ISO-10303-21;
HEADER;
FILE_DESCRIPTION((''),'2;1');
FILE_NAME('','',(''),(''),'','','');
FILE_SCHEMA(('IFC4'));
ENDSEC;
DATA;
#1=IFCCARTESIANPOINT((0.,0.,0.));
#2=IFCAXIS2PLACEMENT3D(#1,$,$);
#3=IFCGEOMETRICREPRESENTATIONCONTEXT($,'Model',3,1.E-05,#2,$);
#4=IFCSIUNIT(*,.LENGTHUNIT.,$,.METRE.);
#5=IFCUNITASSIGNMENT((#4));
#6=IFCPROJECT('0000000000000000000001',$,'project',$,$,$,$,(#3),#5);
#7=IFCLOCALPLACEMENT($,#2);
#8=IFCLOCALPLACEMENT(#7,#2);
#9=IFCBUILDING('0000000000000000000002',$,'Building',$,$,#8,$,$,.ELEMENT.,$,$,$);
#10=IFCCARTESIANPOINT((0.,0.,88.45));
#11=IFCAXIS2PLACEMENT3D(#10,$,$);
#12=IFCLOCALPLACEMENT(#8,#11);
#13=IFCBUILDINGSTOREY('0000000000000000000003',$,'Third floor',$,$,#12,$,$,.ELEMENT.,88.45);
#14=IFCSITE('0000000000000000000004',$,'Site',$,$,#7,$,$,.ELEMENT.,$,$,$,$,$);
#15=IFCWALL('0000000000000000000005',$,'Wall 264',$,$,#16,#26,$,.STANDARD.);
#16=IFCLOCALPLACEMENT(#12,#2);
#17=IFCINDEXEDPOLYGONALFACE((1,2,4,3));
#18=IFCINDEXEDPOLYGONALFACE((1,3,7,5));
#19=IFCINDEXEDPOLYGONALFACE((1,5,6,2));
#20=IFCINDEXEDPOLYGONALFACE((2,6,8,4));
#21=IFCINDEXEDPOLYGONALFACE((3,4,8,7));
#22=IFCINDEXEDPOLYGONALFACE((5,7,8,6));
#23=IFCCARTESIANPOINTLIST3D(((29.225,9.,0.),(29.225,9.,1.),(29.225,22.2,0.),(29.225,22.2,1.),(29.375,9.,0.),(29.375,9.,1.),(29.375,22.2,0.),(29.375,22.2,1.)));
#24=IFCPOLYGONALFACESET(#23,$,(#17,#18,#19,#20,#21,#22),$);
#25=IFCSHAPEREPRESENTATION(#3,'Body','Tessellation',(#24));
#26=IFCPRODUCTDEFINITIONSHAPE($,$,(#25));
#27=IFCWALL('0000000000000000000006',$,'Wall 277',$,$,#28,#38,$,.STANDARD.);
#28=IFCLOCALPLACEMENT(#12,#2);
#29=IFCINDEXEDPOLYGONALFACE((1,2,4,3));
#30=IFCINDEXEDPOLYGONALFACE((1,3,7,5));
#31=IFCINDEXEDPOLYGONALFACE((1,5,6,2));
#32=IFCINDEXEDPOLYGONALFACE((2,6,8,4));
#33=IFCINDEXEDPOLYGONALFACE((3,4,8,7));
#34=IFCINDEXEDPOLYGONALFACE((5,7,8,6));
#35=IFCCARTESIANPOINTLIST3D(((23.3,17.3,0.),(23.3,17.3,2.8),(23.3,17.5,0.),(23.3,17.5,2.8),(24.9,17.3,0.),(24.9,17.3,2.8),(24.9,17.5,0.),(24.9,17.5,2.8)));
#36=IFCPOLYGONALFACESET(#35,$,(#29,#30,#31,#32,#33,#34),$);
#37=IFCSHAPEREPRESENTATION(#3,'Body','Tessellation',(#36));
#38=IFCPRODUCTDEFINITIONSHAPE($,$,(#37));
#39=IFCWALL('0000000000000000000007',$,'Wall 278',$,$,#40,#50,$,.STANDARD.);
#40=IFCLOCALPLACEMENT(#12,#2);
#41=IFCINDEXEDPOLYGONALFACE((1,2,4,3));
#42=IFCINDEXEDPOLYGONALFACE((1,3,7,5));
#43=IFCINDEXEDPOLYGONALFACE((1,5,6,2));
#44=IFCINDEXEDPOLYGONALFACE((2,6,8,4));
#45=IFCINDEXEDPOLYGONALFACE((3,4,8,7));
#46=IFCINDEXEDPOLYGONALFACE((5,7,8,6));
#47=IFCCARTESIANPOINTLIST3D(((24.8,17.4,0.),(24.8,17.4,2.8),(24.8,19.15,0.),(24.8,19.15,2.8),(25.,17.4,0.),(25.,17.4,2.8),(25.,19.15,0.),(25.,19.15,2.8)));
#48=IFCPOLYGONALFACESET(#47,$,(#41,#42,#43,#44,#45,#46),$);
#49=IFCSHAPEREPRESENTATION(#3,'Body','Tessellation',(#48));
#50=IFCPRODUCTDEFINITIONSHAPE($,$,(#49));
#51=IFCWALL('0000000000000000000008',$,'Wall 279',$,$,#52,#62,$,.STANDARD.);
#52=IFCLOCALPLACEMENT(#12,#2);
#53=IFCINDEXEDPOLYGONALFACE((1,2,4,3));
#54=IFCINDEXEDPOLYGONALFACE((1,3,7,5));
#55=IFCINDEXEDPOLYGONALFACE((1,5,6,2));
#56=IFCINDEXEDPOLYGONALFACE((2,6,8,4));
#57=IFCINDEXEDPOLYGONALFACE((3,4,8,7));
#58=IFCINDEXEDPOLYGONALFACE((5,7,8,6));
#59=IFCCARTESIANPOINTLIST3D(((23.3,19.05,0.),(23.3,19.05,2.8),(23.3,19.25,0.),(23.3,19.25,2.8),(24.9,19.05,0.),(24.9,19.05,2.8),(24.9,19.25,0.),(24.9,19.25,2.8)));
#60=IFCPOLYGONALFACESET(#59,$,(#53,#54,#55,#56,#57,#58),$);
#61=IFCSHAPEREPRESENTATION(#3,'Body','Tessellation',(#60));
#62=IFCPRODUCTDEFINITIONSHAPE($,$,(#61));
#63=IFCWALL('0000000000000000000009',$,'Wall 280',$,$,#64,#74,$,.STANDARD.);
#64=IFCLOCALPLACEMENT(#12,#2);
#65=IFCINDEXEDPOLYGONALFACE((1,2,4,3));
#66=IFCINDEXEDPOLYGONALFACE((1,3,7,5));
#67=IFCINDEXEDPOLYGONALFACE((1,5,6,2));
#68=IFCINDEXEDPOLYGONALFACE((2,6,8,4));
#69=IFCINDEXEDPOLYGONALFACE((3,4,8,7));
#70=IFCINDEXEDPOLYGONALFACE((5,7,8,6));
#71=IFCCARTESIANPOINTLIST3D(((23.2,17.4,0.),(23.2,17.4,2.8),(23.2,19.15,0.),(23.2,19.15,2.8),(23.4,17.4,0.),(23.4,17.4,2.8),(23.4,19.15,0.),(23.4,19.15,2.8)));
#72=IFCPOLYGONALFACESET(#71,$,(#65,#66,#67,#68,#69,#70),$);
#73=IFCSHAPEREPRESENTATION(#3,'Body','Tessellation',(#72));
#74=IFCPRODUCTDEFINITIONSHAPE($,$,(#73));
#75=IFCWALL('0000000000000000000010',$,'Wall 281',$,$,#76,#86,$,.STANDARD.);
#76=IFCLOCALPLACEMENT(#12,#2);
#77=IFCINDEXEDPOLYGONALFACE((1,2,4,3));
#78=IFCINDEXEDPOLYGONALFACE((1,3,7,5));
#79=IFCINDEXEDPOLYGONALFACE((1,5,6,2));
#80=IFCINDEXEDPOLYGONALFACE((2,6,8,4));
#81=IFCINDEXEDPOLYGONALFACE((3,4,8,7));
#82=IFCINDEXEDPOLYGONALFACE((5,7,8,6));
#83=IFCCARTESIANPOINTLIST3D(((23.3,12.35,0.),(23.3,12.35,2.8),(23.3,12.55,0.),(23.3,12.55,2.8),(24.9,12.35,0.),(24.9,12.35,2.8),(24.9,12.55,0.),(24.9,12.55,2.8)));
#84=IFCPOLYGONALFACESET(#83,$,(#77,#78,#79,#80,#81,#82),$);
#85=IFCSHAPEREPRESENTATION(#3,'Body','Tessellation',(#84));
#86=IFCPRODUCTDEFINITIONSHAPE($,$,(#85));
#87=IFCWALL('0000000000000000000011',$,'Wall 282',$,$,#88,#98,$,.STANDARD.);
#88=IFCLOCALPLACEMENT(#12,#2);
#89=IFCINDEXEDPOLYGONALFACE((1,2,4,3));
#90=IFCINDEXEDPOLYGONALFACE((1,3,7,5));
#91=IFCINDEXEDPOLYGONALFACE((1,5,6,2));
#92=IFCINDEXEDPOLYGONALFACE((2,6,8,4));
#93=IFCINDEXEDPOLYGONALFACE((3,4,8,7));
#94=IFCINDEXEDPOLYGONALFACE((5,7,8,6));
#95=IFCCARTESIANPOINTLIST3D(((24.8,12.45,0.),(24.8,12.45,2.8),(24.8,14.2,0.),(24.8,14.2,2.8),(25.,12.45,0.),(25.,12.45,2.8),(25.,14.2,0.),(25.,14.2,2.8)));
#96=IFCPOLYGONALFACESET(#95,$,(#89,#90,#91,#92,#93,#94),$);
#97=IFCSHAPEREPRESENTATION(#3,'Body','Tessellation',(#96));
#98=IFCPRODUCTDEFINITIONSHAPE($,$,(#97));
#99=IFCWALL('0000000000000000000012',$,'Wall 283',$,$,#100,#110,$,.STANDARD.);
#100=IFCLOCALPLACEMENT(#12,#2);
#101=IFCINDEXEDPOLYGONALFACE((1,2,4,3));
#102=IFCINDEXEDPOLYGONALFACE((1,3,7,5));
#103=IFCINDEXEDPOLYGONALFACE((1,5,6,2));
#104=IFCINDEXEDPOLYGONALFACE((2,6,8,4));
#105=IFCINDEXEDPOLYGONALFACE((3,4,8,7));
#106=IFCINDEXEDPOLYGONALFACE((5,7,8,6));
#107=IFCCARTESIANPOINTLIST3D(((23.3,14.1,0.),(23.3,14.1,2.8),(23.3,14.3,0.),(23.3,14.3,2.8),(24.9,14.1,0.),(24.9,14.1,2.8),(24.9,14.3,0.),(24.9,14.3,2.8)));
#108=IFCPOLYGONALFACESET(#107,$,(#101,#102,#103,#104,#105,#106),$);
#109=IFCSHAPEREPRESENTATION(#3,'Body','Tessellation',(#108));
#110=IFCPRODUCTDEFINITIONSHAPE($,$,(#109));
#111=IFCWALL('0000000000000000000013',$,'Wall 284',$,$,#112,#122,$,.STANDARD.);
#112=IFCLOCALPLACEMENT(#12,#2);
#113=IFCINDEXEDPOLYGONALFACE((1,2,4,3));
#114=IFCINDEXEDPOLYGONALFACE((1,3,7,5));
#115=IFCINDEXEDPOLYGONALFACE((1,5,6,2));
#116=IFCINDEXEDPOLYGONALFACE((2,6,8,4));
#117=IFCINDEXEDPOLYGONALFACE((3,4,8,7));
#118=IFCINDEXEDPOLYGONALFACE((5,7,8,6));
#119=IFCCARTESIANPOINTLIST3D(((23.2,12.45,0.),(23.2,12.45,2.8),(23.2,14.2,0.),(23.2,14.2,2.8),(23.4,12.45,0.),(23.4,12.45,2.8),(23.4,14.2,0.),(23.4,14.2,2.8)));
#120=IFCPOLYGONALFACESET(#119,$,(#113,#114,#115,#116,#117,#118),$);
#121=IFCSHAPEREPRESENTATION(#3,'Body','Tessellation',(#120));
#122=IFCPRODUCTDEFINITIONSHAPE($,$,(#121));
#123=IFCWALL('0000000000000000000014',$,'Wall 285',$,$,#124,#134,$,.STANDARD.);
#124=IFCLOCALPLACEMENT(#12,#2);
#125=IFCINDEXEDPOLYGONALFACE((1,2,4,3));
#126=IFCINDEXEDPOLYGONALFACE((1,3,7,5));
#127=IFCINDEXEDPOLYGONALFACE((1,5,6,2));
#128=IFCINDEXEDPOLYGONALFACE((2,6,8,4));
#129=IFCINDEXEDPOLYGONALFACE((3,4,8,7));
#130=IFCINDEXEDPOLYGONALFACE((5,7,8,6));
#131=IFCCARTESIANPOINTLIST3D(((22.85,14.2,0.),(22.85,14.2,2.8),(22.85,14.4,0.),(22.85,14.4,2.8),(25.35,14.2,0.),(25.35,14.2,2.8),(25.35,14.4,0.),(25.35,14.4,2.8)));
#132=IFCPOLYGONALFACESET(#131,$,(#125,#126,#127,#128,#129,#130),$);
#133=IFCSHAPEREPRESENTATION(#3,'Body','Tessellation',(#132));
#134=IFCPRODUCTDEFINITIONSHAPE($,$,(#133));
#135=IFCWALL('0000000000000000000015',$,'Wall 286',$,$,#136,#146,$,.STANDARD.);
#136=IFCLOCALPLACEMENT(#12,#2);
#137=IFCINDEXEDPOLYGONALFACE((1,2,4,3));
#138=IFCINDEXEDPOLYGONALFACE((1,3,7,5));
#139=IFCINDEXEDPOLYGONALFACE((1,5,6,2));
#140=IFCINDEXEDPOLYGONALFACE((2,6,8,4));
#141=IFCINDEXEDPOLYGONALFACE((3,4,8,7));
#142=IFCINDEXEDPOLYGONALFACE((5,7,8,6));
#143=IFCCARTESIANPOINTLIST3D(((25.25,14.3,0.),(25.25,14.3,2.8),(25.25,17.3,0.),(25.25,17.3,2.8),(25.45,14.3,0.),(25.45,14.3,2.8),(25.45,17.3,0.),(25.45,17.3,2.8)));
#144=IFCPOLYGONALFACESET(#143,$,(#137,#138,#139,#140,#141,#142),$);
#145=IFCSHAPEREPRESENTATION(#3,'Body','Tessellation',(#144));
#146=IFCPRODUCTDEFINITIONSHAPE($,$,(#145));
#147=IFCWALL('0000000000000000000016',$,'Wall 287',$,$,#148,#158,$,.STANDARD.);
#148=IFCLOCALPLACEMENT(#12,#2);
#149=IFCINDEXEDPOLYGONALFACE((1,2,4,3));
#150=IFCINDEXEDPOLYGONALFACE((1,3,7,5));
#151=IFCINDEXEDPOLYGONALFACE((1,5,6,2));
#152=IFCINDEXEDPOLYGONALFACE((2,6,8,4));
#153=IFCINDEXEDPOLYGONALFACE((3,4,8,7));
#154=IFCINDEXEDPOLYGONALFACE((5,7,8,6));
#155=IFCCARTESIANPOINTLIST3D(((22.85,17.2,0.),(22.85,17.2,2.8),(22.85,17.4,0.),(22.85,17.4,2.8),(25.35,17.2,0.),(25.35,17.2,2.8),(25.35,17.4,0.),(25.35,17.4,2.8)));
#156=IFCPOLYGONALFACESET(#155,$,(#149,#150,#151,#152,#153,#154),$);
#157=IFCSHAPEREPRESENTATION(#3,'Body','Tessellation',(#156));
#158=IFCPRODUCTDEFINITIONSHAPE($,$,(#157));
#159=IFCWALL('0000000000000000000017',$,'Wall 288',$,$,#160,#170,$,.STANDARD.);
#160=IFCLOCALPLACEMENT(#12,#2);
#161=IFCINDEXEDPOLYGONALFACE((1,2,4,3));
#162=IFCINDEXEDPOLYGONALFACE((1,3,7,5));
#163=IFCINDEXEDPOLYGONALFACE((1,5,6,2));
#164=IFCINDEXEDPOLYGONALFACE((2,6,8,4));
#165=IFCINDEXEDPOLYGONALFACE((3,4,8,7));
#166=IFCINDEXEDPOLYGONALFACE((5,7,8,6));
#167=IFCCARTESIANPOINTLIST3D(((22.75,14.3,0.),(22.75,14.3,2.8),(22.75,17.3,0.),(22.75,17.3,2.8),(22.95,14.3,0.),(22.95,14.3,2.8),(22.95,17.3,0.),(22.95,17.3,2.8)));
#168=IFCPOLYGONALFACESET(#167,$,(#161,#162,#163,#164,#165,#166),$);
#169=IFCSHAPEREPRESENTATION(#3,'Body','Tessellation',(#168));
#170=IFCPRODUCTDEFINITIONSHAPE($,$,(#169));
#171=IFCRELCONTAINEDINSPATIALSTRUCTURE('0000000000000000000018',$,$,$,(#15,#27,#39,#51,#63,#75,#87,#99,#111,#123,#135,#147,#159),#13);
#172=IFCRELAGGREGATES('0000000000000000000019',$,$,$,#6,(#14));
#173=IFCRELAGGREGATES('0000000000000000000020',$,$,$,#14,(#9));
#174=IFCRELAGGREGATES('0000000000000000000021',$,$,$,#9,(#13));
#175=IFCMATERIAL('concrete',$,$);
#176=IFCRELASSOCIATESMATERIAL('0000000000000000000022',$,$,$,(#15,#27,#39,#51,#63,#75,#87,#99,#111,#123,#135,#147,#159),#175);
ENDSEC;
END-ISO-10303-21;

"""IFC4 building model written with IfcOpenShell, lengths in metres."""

from ifc_helpers import new_model, si_unit, frame, frame_2d, origin, place, context, project, spatial, rectangle, extrude, material, element, save


model = new_model("IFC4")

# Units and contexts
model_context = context("Model", 3, precision=1e-05, world=origin())
ifc_project = project(units=[si_unit("LENGTHUNIT", "METRE")], contexts=[model_context])

# Site, building, storey
site_placement = place(None, origin())
site = spatial("IfcSite", under=ifc_project, at=site_placement, Name="Site", CompositionType="ELEMENT")
building_placement = place(site_placement, origin())
building = spatial("IfcBuilding", under=site, at=building_placement, Name="Building", CompositionType="ELEMENT")
storey_placement = place(building_placement, frame((0.0, 0.0, 88.45)))
storey = spatial("IfcBuildingStorey", under=building, at=storey_placement, Name="Third floor", CompositionType="ELEMENT", Elevation=88.45)

# Shared definitions
ifc_material = material(Name="concrete")

# Walls
wall_1_placement = place(storey_placement, frame((29.3, 22.2, 0.0), z_axis=(0.0, 0.0, 1.0), x_axis=(0.0, -1.0, 0.0)))
element("IfcWall", 1, at=wall_1_placement, inside=storey, material=ifc_material, Name="Wall 264", PredefinedType="STANDARD", context=model_context, shape_type="SweptSolid", body=[
    extrude(rectangle(XDim=13.2, YDim=0.15, at=frame_2d((6.6, 0.0))), origin(), (0.0, 0.0, 1.0), 1.0),
])
wall_2_placement = place(storey_placement, frame((23.3, 17.4, 0.0), z_axis=(0.0, 0.0, 1.0), x_axis=(1.0, 0.0, 0.0)))
element("IfcWall", 2, at=wall_2_placement, inside=storey, material=ifc_material, Name="Wall 277", PredefinedType="STANDARD", context=model_context, shape_type="SweptSolid", body=[
    extrude(rectangle(XDim=1.6, YDim=0.2, at=frame_2d((0.8, 0.0))), origin(), (0.0, 0.0, 1.0), 2.8),
])
wall_3_placement = place(storey_placement, frame((24.9, 17.4, 0.0), z_axis=(0.0, 0.0, 1.0), x_axis=(0.0, 1.0, 0.0)))
element("IfcWall", 3, at=wall_3_placement, inside=storey, material=ifc_material, Name="Wall 278", PredefinedType="STANDARD", context=model_context, shape_type="SweptSolid", body=[
    extrude(rectangle(XDim=1.75, YDim=0.2, at=frame_2d((0.875, 0.0))), origin(), (0.0, 0.0, 1.0), 2.8),
])
wall_4_placement = place(storey_placement, frame((24.9, 19.15, 0.0), z_axis=(0.0, 0.0, 1.0), x_axis=(-1.0, 0.0, 0.0)))
element("IfcWall", 4, at=wall_4_placement, inside=storey, material=ifc_material, Name="Wall 279", PredefinedType="STANDARD", context=model_context, shape_type="SweptSolid", body=[
    extrude(rectangle(XDim=1.6, YDim=0.2, at=frame_2d((0.8, 0.0))), origin(), (0.0, 0.0, 1.0), 2.8),
])
wall_5_placement = place(storey_placement, frame((23.3, 19.15, 0.0), z_axis=(0.0, 0.0, 1.0), x_axis=(0.0, -1.0, 0.0)))
element("IfcWall", 5, at=wall_5_placement, inside=storey, material=ifc_material, Name="Wall 280", PredefinedType="STANDARD", context=model_context, shape_type="SweptSolid", body=[
    extrude(rectangle(XDim=1.75, YDim=0.2, at=frame_2d((0.875, 0.0))), origin(), (0.0, 0.0, 1.0), 2.8),
])
wall_6_placement = place(storey_placement, frame((23.3, 12.45, 0.0), z_axis=(0.0, 0.0, 1.0), x_axis=(1.0, 0.0, 0.0)))
element("IfcWall", 6, at=wall_6_placement, inside=storey, material=ifc_material, Name="Wall 281", PredefinedType="STANDARD", context=model_context, shape_type="SweptSolid", body=[
    extrude(rectangle(XDim=1.6, YDim=0.2, at=frame_2d((0.8, 0.0))), origin(), (0.0, 0.0, 1.0), 2.8),
])
wall_7_placement = place(storey_placement, frame((24.9, 12.45, 0.0), z_axis=(0.0, 0.0, 1.0), x_axis=(0.0, 1.0, 0.0)))
element("IfcWall", 7, at=wall_7_placement, inside=storey, material=ifc_material, Name="Wall 282", PredefinedType="STANDARD", context=model_context, shape_type="SweptSolid", body=[
    extrude(rectangle(XDim=1.75, YDim=0.2, at=frame_2d((0.875, 0.0))), origin(), (0.0, 0.0, 1.0), 2.8),
])
wall_8_placement = place(storey_placement, frame((24.9, 14.2, 0.0), z_axis=(0.0, 0.0, 1.0), x_axis=(-1.0, 0.0, 0.0)))
element("IfcWall", 8, at=wall_8_placement, inside=storey, material=ifc_material, Name="Wall 283", PredefinedType="STANDARD", context=model_context, shape_type="SweptSolid", body=[
    extrude(rectangle(XDim=1.6, YDim=0.2, at=frame_2d((0.8, 0.0))), origin(), (0.0, 0.0, 1.0), 2.8),
])
wall_9_placement = place(storey_placement, frame((23.3, 14.2, 0.0), z_axis=(0.0, 0.0, 1.0), x_axis=(0.0, -1.0, 0.0)))
element("IfcWall", 9, at=wall_9_placement, inside=storey, material=ifc_material, Name="Wall 284", PredefinedType="STANDARD", context=model_context, shape_type="SweptSolid", body=[
    extrude(rectangle(XDim=1.75, YDim=0.2, at=frame_2d((0.875, 0.0))), origin(), (0.0, 0.0, 1.0), 2.8),
])
wall_10_placement = place(storey_placement, frame((22.85, 14.3, 0.0), z_axis=(0.0, 0.0, 1.0), x_axis=(1.0, 0.0, 0.0)))
element("IfcWall", 10, at=wall_10_placement, inside=storey, material=ifc_material, Name="Wall 285", PredefinedType="STANDARD", context=model_context, shape_type="SweptSolid", body=[
    extrude(rectangle(XDim=2.5, YDim=0.2, at=frame_2d((1.25, 0.0))), origin(), (0.0, 0.0, 1.0), 2.8),
])
wall_11_placement = place(storey_placement, frame((25.35, 14.3, 0.0), z_axis=(0.0, 0.0, 1.0), x_axis=(0.0, 1.0, 0.0)))
element("IfcWall", 11, at=wall_11_placement, inside=storey, material=ifc_material, Name="Wall 286", PredefinedType="STANDARD", context=model_context, shape_type="SweptSolid", body=[
    extrude(rectangle(XDim=3.0, YDim=0.2, at=frame_2d((1.5, 0.0))), origin(), (0.0, 0.0, 1.0), 2.8),
])
wall_12_placement = place(storey_placement, frame((25.35, 17.3, 0.0), z_axis=(0.0, 0.0, 1.0), x_axis=(-1.0, 0.0, 0.0)))
element("IfcWall", 12, at=wall_12_placement, inside=storey, material=ifc_material, Name="Wall 287", PredefinedType="STANDARD", context=model_context, shape_type="SweptSolid", body=[
    extrude(rectangle(XDim=2.5, YDim=0.2, at=frame_2d((1.25, 0.0))), origin(), (0.0, 0.0, 1.0), 2.8),
])
wall_13_placement = place(storey_placement, frame((22.85, 17.3, 0.0), z_axis=(0.0, 0.0, 1.0), x_axis=(0.0, -1.0, 0.0)))
element("IfcWall", 13, at=wall_13_placement, inside=storey, material=ifc_material, Name="Wall 288", PredefinedType="STANDARD", context=model_context, shape_type="SweptSolid", body=[
    extrude(rectangle(XDim=3.0, YDim=0.2, at=frame_2d((1.5, 0.0))), origin(), (0.0, 0.0, 1.0), 2.8),
])

save(model, "model.ifc")
